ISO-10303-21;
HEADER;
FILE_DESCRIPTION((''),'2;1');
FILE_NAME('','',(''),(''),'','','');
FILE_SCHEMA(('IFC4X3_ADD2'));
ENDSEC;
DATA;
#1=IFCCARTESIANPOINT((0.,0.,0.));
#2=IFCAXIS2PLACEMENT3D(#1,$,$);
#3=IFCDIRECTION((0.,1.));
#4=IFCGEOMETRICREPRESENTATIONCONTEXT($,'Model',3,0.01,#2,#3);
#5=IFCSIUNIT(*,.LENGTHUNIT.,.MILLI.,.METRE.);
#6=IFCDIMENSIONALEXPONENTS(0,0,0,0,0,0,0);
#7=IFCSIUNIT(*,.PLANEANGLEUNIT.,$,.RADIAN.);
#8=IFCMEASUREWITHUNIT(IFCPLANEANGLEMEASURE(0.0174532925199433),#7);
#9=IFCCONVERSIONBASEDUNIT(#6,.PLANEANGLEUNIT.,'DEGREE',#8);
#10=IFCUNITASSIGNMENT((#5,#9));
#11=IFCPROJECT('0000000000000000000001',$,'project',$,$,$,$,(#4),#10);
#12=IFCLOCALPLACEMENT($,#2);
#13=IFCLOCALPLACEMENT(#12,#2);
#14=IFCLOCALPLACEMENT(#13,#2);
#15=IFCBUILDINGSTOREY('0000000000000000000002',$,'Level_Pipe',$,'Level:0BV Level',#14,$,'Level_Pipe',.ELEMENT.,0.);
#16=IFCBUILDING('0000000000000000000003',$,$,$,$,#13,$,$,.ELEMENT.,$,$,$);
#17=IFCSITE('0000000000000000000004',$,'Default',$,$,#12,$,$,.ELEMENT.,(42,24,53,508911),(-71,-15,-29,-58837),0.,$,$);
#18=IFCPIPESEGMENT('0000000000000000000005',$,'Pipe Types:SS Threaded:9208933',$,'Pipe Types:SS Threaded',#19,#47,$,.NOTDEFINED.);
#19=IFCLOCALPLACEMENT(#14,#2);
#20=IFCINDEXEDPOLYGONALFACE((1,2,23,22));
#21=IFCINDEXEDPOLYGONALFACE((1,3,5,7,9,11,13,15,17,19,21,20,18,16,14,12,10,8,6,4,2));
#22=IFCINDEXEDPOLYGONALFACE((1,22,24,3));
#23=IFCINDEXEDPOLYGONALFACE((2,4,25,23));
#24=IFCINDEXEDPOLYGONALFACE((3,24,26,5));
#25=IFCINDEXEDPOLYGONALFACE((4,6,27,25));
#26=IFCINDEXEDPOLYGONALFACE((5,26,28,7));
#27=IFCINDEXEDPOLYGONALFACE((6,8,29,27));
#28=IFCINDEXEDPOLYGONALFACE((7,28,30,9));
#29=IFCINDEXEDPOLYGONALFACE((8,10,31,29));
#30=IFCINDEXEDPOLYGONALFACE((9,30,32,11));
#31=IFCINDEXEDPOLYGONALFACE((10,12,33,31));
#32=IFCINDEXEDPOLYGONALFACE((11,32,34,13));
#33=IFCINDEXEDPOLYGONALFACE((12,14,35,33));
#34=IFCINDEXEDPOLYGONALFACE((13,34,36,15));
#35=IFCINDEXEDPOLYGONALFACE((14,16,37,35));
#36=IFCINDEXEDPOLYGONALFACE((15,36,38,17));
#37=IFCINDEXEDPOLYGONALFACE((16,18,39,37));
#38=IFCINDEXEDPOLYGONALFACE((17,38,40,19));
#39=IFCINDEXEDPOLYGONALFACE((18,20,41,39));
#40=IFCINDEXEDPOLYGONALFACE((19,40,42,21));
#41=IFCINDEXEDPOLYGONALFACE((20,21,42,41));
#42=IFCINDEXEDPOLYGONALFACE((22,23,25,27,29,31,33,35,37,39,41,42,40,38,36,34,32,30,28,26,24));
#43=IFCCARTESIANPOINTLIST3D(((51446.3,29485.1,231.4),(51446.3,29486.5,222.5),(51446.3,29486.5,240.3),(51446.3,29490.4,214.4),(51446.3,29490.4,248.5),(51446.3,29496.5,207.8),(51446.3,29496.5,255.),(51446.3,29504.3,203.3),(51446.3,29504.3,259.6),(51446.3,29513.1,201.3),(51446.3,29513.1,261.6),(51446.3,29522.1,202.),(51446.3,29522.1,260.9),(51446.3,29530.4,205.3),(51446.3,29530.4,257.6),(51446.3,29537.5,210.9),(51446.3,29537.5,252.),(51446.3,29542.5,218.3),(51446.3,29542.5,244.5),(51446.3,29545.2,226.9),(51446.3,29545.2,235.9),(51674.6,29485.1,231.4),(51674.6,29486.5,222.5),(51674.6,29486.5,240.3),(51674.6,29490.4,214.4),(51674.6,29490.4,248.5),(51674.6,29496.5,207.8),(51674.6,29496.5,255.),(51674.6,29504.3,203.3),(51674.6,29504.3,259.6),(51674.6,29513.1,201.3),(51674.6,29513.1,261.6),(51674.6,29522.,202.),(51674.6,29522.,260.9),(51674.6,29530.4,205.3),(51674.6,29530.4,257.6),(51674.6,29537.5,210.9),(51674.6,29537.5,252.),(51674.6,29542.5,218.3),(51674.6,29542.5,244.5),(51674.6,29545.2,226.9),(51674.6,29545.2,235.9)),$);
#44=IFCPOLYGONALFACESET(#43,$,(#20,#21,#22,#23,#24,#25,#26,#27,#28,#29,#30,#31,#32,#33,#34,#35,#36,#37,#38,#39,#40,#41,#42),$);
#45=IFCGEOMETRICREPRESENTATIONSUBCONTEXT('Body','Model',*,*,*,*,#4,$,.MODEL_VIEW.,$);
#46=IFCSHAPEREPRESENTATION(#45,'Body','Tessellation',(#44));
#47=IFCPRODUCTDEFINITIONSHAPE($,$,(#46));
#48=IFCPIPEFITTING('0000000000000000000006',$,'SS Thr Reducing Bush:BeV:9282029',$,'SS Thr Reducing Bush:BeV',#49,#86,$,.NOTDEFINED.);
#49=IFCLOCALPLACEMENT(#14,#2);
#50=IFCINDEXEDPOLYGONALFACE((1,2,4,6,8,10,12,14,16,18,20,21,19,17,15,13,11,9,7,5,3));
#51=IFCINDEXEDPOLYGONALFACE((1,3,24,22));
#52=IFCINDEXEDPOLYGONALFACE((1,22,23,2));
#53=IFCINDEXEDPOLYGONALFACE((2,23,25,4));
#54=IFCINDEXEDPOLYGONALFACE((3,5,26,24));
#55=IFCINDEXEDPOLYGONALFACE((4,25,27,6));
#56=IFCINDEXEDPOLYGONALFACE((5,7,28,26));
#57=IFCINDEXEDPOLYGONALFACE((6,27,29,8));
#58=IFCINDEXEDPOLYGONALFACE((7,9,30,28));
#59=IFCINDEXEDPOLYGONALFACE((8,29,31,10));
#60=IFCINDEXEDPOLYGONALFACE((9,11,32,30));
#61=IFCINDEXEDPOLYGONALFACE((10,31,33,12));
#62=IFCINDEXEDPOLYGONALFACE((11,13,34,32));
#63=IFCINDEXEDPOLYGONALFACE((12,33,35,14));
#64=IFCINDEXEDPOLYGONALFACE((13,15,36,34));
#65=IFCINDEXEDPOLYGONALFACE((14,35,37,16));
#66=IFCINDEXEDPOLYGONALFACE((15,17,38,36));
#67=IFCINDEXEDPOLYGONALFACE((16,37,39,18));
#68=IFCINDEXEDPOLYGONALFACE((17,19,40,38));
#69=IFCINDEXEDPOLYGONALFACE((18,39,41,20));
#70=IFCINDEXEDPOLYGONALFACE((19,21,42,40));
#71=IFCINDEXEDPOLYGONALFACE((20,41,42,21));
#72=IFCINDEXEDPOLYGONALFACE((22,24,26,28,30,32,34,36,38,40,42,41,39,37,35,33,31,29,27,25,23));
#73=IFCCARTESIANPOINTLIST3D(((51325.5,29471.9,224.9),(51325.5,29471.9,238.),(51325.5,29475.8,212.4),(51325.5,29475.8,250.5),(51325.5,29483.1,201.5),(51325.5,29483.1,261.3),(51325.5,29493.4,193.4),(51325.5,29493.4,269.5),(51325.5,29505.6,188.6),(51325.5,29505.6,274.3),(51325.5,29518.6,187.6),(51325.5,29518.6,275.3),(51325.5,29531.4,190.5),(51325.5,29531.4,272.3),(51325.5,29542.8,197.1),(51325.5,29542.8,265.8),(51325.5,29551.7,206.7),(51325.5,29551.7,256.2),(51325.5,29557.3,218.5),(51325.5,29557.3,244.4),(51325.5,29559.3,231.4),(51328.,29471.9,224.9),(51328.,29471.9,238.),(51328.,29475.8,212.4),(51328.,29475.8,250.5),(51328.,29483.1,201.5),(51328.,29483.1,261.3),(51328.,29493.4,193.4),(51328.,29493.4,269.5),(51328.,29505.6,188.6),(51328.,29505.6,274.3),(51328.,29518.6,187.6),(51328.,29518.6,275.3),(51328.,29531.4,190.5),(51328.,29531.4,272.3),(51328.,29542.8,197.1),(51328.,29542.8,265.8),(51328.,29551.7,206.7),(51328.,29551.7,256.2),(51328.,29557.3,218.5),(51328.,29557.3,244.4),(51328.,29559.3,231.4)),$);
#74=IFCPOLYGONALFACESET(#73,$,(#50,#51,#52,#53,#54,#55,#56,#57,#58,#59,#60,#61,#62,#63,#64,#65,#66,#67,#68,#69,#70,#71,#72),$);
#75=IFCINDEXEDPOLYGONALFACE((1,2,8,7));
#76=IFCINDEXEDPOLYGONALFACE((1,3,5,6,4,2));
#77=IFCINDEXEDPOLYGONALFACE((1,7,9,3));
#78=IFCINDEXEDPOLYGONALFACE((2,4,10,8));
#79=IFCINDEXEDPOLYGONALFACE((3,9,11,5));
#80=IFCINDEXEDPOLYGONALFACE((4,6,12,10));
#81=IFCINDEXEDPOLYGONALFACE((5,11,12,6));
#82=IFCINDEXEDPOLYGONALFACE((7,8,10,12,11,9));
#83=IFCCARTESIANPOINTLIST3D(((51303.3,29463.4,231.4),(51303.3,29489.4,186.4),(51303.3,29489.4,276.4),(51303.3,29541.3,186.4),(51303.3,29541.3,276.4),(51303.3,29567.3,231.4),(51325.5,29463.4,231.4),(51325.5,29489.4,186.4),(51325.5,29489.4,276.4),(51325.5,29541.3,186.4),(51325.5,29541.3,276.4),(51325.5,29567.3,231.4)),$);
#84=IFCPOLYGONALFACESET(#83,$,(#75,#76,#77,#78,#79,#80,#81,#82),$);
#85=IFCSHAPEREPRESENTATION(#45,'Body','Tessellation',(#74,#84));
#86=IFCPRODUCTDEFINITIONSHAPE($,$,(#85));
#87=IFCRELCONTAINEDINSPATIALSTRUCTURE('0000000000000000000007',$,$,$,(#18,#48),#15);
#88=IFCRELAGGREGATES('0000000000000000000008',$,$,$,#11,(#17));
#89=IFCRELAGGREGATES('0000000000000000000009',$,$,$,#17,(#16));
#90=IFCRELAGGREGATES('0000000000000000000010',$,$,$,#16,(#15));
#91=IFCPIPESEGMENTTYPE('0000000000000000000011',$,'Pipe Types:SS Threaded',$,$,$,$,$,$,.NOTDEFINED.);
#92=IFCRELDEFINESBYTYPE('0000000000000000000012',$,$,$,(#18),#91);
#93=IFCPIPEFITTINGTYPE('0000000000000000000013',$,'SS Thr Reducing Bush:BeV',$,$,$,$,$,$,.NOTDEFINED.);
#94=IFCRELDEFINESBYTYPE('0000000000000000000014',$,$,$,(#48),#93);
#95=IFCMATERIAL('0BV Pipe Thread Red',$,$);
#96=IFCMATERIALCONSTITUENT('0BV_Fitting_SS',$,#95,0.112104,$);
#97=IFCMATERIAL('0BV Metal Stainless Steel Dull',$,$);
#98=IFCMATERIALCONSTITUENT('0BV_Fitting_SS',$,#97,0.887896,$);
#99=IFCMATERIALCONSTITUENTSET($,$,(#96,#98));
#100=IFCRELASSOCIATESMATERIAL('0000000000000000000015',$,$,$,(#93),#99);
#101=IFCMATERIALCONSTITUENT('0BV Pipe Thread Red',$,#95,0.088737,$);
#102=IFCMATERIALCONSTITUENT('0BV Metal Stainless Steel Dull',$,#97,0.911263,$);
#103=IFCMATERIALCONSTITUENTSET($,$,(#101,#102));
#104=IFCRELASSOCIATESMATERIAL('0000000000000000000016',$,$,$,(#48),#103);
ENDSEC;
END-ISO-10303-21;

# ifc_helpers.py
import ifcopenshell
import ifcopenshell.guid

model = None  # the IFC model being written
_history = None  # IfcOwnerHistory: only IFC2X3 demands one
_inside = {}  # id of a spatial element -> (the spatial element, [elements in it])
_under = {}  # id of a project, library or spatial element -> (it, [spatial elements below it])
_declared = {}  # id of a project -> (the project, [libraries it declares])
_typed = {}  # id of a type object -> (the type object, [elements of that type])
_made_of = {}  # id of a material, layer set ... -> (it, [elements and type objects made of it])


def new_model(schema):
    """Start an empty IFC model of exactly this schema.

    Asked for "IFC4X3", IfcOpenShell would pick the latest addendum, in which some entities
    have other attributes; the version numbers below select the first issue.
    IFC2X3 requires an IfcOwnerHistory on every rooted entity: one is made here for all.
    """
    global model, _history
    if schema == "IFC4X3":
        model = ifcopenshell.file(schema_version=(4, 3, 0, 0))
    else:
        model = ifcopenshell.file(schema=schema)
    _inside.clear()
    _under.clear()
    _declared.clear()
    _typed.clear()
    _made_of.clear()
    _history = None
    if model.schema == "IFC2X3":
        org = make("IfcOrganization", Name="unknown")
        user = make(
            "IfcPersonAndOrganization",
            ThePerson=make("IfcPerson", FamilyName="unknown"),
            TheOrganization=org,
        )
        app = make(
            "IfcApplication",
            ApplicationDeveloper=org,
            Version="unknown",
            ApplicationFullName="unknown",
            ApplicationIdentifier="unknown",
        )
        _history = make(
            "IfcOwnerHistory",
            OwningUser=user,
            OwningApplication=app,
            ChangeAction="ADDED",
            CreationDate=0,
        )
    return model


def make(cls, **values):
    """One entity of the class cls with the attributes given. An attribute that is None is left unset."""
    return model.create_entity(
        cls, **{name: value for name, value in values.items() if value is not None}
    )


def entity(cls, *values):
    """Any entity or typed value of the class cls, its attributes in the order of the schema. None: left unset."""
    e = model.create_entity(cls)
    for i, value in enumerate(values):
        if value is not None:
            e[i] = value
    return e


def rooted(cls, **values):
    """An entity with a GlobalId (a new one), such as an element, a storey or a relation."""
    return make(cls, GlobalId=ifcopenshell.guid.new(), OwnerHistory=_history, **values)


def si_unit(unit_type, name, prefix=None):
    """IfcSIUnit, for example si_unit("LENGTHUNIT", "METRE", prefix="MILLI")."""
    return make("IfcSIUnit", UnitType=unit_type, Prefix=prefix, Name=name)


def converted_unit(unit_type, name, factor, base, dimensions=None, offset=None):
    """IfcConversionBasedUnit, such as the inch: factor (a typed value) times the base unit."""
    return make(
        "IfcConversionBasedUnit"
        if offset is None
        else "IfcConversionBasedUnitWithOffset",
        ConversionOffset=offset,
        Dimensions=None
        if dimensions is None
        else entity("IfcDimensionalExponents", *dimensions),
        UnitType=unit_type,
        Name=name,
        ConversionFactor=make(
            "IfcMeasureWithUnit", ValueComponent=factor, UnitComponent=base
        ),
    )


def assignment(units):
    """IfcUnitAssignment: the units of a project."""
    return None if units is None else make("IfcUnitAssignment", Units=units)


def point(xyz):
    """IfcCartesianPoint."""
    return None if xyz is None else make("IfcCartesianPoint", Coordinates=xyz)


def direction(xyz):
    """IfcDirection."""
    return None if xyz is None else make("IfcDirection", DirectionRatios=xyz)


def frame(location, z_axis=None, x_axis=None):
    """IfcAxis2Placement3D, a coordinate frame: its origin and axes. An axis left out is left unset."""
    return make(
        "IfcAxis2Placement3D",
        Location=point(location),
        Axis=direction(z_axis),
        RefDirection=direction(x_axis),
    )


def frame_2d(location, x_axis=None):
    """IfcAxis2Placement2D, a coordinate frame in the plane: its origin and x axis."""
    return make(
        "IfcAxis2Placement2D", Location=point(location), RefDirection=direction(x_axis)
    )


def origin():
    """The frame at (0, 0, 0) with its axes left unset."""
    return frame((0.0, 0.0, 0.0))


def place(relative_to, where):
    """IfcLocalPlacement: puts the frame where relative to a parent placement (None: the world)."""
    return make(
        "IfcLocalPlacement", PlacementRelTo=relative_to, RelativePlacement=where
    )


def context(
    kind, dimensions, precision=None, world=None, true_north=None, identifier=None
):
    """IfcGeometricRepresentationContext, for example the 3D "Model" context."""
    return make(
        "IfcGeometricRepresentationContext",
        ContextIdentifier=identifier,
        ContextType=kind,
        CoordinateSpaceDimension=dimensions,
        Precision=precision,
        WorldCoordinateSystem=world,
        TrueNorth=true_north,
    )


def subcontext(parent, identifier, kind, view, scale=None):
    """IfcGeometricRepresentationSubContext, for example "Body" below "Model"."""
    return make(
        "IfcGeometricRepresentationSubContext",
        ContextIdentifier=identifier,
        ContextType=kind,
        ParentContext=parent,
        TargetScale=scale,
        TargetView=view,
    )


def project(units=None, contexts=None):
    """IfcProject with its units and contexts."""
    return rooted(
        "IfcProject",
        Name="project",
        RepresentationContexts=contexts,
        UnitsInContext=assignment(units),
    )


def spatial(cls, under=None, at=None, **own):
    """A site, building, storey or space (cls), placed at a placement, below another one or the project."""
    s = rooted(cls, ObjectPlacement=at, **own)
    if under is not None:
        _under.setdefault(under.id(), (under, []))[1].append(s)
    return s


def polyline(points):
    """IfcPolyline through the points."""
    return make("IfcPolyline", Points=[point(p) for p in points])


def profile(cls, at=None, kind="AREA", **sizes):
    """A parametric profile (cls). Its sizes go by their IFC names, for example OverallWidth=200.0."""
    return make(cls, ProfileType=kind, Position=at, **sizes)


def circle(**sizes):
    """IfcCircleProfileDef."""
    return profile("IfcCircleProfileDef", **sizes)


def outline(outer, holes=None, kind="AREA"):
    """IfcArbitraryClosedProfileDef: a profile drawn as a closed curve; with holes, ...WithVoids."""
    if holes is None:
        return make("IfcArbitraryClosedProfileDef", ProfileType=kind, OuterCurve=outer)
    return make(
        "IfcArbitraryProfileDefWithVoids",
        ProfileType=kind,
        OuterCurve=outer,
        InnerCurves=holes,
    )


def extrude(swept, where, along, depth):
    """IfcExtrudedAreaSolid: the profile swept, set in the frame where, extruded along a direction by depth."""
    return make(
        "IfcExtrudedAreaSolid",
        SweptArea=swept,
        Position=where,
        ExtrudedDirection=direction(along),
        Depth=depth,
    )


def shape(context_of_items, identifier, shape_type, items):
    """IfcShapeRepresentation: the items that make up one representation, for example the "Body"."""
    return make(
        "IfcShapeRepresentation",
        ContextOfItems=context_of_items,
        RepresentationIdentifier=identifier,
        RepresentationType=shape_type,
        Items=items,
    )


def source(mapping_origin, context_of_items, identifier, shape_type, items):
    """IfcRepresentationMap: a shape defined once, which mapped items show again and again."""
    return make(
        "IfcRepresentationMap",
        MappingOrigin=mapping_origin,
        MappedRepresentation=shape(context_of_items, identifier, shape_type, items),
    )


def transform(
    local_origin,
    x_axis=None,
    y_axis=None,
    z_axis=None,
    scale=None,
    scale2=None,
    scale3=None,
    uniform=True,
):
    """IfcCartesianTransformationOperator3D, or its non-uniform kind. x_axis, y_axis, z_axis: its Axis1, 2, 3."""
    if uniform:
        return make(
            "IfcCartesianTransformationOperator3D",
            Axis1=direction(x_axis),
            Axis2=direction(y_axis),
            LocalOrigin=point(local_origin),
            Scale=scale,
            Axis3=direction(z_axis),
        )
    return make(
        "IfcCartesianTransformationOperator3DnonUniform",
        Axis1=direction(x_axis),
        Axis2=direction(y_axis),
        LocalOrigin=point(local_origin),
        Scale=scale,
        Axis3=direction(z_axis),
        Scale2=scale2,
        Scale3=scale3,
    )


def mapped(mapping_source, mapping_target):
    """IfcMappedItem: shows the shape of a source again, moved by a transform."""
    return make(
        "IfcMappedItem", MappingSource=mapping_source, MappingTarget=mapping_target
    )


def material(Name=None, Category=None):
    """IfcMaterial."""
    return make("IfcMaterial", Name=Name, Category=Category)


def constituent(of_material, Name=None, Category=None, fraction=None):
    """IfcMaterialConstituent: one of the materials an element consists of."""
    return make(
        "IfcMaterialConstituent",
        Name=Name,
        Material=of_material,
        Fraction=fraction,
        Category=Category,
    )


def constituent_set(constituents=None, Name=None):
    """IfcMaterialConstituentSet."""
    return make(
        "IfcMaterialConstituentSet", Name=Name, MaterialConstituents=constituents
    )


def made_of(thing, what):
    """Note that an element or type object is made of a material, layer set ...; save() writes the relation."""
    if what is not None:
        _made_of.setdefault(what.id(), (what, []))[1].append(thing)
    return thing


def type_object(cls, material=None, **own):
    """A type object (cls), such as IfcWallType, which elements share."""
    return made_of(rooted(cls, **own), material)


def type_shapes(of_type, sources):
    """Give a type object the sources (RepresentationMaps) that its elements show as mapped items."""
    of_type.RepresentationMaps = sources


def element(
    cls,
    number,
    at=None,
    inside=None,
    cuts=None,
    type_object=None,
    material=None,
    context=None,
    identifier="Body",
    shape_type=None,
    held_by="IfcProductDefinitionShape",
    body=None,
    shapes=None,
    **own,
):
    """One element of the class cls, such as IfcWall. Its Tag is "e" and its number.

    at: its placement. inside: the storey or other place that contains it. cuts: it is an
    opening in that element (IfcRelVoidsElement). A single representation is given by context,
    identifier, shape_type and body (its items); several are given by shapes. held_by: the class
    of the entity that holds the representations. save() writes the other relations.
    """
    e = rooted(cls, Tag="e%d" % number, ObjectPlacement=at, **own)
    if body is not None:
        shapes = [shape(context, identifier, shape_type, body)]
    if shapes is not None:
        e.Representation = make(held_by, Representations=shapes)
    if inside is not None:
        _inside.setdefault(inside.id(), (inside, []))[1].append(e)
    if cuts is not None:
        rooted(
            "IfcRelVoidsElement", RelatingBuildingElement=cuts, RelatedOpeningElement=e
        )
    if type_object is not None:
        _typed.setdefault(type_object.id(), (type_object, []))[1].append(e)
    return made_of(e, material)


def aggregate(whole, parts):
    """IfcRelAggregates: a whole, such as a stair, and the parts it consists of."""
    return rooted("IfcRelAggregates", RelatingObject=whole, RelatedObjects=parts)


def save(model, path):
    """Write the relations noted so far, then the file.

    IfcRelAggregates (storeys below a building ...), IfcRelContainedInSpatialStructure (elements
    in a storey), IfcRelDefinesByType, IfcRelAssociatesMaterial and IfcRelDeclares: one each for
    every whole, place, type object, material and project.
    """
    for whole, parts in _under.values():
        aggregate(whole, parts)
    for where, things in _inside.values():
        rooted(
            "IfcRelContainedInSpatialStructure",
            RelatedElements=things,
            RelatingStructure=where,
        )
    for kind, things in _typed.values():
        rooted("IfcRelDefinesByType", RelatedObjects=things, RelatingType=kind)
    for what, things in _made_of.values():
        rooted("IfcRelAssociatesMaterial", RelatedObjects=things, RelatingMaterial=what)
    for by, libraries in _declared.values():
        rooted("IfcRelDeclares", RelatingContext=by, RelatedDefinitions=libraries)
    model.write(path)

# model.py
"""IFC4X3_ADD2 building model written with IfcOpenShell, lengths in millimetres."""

from ifc_helpers import new_model, entity, si_unit, converted_unit, direction, frame, frame_2d, origin, place, context, subcontext, project, spatial, polyline, circle, outline, extrude, source, transform, mapped, material, constituent, constituent_set, type_object, type_shapes, element, save


model = new_model("IFC4X3_ADD2")

# Units and contexts
model_context = context("Model", 3, precision=0.01, world=origin(), true_north=direction((0.0, 1.0)))
body_context = subcontext(model_context, "Body", "Model", "MODEL_VIEW")
ifc_project = project(units=[si_unit("LENGTHUNIT", "METRE", prefix="MILLI"), converted_unit("PLANEANGLEUNIT", "DEGREE", entity("IfcPlaneAngleMeasure", 0.0174532925199433), si_unit("PLANEANGLEUNIT", "RADIAN"), dimensions=[0, 0, 0, 0, 0, 0, 0])], contexts=[model_context])

# Site, building, storey
site_placement = place(None, origin())
site = spatial("IfcSite", under=ifc_project, at=site_placement, Name="Default", CompositionType="ELEMENT", RefLatitude=(42, 24, 53, 508911), RefLongitude=(-71, -15, -29, -58837), RefElevation=0.0)
building_placement = place(site_placement, origin())
building = spatial("IfcBuilding", under=site, at=building_placement, CompositionType="ELEMENT")
storey_placement = place(building_placement, origin())
storey = spatial("IfcBuildingStorey", under=building, at=storey_placement, Name="Level_Pipe", ObjectType="Level:0BV Level", LongName="Level_Pipe", CompositionType="ELEMENT", Elevation=0.0)

# Shared definitions
ifc_material_1 = material(Name="0BV Metal Stainless Steel Dull")
ifc_material_2 = material(Name="0BV Pipe Thread Red")

# Pipe segment
pipe_segment_type_1 = type_object("IfcPipeSegmentType", Name="Pipe Types:SS Threaded", PredefinedType="NOTDEFINED")
pipe_segment_1_placement = place(storey_placement, frame((51446.3, 29483.5, 263.2)))
element("IfcPipeSegment", 1, at=pipe_segment_1_placement, inside=storey, type_object=pipe_segment_type_1, Name="Pipe Types:SS Threaded:9208933", ObjectType="Pipe Types:SS Threaded", PredefinedType="NOTDEFINED", context=body_context, shape_type="SweptSolid", body=[
    extrude(circle(Radius=30.2, at=frame_2d((0.0, 0.0), x_axis=(1.0, 0.0))), frame((0.0, 31.8, -31.8), z_axis=(1.0, -0.000001, 0.0), x_axis=(-0.000001, -1.0, 0.0)), (0.0, 0.0, 1.0), 228.3),
])

# Pipe fitting
ifc_constituent_1 = constituent(ifc_material_2, Name="0BV Pipe Thread Red", fraction=0.088737)
ifc_constituent_2 = constituent(ifc_material_1, Name="0BV Metal Stainless Steel Dull", fraction=0.911263)
ifc_constituent_set_1 = constituent_set(constituents=[ifc_constituent_1, ifc_constituent_2])
ifc_constituent_3 = constituent(ifc_material_2, Name="0BV_Fitting_SS", fraction=0.112104)
ifc_constituent_4 = constituent(ifc_material_1, Name="0BV_Fitting_SS", fraction=0.887896)
ifc_constituent_set_2 = constituent_set(constituents=[ifc_constituent_3, ifc_constituent_4])
pipe_fitting_type_1 = type_object("IfcPipeFittingType", Name="SS Thr Reducing Bush:BeV", PredefinedType="NOTDEFINED", material=ifc_constituent_set_2)
shared_shape_1 = source(origin(), body_context, "Body", "SweptSolid", [
    extrude(circle(Radius=43.9, at=frame_2d((0.0, 0.0), x_axis=(1.0, 0.0))), frame((22.2, 0.0, 0.0), z_axis=(1.0, 0.0, 0.0), x_axis=(0.0, 1.0, 0.0)), (0.0, 0.0, 1.0), 2.5),
    extrude(outline(polyline([(-26.0, -45.0), (26.0, -45.0), (52.0, 0.0), (26.0, 45.0), (-26.0, 45.0), (-52.0, 0.0), (-26.0, -45.0)])), frame((0.0, 0.0, 0.0), z_axis=(1.0, 0.0, 0.0), x_axis=(0.0, -0.5, -0.866025)), (0.0, 0.0, 1.0), 22.2),
])
type_shapes(pipe_fitting_type_1, [shared_shape_1])
pipe_fitting_1_placement = place(storey_placement, frame((51303.3, 29515.4, 231.4)))
element("IfcPipeFitting", 2, at=pipe_fitting_1_placement, inside=storey, type_object=pipe_fitting_type_1, material=ifc_constituent_set_1, Name="SS Thr Reducing Bush:BeV:9282029", ObjectType="SS Thr Reducing Bush:BeV", PredefinedType="NOTDEFINED", context=body_context, shape_type="MappedRepresentation", body=[
    mapped(shared_shape_1, transform((0.0, 0.0, 0.0), scale=1.0)),
])

save(model, "model.ifc")
